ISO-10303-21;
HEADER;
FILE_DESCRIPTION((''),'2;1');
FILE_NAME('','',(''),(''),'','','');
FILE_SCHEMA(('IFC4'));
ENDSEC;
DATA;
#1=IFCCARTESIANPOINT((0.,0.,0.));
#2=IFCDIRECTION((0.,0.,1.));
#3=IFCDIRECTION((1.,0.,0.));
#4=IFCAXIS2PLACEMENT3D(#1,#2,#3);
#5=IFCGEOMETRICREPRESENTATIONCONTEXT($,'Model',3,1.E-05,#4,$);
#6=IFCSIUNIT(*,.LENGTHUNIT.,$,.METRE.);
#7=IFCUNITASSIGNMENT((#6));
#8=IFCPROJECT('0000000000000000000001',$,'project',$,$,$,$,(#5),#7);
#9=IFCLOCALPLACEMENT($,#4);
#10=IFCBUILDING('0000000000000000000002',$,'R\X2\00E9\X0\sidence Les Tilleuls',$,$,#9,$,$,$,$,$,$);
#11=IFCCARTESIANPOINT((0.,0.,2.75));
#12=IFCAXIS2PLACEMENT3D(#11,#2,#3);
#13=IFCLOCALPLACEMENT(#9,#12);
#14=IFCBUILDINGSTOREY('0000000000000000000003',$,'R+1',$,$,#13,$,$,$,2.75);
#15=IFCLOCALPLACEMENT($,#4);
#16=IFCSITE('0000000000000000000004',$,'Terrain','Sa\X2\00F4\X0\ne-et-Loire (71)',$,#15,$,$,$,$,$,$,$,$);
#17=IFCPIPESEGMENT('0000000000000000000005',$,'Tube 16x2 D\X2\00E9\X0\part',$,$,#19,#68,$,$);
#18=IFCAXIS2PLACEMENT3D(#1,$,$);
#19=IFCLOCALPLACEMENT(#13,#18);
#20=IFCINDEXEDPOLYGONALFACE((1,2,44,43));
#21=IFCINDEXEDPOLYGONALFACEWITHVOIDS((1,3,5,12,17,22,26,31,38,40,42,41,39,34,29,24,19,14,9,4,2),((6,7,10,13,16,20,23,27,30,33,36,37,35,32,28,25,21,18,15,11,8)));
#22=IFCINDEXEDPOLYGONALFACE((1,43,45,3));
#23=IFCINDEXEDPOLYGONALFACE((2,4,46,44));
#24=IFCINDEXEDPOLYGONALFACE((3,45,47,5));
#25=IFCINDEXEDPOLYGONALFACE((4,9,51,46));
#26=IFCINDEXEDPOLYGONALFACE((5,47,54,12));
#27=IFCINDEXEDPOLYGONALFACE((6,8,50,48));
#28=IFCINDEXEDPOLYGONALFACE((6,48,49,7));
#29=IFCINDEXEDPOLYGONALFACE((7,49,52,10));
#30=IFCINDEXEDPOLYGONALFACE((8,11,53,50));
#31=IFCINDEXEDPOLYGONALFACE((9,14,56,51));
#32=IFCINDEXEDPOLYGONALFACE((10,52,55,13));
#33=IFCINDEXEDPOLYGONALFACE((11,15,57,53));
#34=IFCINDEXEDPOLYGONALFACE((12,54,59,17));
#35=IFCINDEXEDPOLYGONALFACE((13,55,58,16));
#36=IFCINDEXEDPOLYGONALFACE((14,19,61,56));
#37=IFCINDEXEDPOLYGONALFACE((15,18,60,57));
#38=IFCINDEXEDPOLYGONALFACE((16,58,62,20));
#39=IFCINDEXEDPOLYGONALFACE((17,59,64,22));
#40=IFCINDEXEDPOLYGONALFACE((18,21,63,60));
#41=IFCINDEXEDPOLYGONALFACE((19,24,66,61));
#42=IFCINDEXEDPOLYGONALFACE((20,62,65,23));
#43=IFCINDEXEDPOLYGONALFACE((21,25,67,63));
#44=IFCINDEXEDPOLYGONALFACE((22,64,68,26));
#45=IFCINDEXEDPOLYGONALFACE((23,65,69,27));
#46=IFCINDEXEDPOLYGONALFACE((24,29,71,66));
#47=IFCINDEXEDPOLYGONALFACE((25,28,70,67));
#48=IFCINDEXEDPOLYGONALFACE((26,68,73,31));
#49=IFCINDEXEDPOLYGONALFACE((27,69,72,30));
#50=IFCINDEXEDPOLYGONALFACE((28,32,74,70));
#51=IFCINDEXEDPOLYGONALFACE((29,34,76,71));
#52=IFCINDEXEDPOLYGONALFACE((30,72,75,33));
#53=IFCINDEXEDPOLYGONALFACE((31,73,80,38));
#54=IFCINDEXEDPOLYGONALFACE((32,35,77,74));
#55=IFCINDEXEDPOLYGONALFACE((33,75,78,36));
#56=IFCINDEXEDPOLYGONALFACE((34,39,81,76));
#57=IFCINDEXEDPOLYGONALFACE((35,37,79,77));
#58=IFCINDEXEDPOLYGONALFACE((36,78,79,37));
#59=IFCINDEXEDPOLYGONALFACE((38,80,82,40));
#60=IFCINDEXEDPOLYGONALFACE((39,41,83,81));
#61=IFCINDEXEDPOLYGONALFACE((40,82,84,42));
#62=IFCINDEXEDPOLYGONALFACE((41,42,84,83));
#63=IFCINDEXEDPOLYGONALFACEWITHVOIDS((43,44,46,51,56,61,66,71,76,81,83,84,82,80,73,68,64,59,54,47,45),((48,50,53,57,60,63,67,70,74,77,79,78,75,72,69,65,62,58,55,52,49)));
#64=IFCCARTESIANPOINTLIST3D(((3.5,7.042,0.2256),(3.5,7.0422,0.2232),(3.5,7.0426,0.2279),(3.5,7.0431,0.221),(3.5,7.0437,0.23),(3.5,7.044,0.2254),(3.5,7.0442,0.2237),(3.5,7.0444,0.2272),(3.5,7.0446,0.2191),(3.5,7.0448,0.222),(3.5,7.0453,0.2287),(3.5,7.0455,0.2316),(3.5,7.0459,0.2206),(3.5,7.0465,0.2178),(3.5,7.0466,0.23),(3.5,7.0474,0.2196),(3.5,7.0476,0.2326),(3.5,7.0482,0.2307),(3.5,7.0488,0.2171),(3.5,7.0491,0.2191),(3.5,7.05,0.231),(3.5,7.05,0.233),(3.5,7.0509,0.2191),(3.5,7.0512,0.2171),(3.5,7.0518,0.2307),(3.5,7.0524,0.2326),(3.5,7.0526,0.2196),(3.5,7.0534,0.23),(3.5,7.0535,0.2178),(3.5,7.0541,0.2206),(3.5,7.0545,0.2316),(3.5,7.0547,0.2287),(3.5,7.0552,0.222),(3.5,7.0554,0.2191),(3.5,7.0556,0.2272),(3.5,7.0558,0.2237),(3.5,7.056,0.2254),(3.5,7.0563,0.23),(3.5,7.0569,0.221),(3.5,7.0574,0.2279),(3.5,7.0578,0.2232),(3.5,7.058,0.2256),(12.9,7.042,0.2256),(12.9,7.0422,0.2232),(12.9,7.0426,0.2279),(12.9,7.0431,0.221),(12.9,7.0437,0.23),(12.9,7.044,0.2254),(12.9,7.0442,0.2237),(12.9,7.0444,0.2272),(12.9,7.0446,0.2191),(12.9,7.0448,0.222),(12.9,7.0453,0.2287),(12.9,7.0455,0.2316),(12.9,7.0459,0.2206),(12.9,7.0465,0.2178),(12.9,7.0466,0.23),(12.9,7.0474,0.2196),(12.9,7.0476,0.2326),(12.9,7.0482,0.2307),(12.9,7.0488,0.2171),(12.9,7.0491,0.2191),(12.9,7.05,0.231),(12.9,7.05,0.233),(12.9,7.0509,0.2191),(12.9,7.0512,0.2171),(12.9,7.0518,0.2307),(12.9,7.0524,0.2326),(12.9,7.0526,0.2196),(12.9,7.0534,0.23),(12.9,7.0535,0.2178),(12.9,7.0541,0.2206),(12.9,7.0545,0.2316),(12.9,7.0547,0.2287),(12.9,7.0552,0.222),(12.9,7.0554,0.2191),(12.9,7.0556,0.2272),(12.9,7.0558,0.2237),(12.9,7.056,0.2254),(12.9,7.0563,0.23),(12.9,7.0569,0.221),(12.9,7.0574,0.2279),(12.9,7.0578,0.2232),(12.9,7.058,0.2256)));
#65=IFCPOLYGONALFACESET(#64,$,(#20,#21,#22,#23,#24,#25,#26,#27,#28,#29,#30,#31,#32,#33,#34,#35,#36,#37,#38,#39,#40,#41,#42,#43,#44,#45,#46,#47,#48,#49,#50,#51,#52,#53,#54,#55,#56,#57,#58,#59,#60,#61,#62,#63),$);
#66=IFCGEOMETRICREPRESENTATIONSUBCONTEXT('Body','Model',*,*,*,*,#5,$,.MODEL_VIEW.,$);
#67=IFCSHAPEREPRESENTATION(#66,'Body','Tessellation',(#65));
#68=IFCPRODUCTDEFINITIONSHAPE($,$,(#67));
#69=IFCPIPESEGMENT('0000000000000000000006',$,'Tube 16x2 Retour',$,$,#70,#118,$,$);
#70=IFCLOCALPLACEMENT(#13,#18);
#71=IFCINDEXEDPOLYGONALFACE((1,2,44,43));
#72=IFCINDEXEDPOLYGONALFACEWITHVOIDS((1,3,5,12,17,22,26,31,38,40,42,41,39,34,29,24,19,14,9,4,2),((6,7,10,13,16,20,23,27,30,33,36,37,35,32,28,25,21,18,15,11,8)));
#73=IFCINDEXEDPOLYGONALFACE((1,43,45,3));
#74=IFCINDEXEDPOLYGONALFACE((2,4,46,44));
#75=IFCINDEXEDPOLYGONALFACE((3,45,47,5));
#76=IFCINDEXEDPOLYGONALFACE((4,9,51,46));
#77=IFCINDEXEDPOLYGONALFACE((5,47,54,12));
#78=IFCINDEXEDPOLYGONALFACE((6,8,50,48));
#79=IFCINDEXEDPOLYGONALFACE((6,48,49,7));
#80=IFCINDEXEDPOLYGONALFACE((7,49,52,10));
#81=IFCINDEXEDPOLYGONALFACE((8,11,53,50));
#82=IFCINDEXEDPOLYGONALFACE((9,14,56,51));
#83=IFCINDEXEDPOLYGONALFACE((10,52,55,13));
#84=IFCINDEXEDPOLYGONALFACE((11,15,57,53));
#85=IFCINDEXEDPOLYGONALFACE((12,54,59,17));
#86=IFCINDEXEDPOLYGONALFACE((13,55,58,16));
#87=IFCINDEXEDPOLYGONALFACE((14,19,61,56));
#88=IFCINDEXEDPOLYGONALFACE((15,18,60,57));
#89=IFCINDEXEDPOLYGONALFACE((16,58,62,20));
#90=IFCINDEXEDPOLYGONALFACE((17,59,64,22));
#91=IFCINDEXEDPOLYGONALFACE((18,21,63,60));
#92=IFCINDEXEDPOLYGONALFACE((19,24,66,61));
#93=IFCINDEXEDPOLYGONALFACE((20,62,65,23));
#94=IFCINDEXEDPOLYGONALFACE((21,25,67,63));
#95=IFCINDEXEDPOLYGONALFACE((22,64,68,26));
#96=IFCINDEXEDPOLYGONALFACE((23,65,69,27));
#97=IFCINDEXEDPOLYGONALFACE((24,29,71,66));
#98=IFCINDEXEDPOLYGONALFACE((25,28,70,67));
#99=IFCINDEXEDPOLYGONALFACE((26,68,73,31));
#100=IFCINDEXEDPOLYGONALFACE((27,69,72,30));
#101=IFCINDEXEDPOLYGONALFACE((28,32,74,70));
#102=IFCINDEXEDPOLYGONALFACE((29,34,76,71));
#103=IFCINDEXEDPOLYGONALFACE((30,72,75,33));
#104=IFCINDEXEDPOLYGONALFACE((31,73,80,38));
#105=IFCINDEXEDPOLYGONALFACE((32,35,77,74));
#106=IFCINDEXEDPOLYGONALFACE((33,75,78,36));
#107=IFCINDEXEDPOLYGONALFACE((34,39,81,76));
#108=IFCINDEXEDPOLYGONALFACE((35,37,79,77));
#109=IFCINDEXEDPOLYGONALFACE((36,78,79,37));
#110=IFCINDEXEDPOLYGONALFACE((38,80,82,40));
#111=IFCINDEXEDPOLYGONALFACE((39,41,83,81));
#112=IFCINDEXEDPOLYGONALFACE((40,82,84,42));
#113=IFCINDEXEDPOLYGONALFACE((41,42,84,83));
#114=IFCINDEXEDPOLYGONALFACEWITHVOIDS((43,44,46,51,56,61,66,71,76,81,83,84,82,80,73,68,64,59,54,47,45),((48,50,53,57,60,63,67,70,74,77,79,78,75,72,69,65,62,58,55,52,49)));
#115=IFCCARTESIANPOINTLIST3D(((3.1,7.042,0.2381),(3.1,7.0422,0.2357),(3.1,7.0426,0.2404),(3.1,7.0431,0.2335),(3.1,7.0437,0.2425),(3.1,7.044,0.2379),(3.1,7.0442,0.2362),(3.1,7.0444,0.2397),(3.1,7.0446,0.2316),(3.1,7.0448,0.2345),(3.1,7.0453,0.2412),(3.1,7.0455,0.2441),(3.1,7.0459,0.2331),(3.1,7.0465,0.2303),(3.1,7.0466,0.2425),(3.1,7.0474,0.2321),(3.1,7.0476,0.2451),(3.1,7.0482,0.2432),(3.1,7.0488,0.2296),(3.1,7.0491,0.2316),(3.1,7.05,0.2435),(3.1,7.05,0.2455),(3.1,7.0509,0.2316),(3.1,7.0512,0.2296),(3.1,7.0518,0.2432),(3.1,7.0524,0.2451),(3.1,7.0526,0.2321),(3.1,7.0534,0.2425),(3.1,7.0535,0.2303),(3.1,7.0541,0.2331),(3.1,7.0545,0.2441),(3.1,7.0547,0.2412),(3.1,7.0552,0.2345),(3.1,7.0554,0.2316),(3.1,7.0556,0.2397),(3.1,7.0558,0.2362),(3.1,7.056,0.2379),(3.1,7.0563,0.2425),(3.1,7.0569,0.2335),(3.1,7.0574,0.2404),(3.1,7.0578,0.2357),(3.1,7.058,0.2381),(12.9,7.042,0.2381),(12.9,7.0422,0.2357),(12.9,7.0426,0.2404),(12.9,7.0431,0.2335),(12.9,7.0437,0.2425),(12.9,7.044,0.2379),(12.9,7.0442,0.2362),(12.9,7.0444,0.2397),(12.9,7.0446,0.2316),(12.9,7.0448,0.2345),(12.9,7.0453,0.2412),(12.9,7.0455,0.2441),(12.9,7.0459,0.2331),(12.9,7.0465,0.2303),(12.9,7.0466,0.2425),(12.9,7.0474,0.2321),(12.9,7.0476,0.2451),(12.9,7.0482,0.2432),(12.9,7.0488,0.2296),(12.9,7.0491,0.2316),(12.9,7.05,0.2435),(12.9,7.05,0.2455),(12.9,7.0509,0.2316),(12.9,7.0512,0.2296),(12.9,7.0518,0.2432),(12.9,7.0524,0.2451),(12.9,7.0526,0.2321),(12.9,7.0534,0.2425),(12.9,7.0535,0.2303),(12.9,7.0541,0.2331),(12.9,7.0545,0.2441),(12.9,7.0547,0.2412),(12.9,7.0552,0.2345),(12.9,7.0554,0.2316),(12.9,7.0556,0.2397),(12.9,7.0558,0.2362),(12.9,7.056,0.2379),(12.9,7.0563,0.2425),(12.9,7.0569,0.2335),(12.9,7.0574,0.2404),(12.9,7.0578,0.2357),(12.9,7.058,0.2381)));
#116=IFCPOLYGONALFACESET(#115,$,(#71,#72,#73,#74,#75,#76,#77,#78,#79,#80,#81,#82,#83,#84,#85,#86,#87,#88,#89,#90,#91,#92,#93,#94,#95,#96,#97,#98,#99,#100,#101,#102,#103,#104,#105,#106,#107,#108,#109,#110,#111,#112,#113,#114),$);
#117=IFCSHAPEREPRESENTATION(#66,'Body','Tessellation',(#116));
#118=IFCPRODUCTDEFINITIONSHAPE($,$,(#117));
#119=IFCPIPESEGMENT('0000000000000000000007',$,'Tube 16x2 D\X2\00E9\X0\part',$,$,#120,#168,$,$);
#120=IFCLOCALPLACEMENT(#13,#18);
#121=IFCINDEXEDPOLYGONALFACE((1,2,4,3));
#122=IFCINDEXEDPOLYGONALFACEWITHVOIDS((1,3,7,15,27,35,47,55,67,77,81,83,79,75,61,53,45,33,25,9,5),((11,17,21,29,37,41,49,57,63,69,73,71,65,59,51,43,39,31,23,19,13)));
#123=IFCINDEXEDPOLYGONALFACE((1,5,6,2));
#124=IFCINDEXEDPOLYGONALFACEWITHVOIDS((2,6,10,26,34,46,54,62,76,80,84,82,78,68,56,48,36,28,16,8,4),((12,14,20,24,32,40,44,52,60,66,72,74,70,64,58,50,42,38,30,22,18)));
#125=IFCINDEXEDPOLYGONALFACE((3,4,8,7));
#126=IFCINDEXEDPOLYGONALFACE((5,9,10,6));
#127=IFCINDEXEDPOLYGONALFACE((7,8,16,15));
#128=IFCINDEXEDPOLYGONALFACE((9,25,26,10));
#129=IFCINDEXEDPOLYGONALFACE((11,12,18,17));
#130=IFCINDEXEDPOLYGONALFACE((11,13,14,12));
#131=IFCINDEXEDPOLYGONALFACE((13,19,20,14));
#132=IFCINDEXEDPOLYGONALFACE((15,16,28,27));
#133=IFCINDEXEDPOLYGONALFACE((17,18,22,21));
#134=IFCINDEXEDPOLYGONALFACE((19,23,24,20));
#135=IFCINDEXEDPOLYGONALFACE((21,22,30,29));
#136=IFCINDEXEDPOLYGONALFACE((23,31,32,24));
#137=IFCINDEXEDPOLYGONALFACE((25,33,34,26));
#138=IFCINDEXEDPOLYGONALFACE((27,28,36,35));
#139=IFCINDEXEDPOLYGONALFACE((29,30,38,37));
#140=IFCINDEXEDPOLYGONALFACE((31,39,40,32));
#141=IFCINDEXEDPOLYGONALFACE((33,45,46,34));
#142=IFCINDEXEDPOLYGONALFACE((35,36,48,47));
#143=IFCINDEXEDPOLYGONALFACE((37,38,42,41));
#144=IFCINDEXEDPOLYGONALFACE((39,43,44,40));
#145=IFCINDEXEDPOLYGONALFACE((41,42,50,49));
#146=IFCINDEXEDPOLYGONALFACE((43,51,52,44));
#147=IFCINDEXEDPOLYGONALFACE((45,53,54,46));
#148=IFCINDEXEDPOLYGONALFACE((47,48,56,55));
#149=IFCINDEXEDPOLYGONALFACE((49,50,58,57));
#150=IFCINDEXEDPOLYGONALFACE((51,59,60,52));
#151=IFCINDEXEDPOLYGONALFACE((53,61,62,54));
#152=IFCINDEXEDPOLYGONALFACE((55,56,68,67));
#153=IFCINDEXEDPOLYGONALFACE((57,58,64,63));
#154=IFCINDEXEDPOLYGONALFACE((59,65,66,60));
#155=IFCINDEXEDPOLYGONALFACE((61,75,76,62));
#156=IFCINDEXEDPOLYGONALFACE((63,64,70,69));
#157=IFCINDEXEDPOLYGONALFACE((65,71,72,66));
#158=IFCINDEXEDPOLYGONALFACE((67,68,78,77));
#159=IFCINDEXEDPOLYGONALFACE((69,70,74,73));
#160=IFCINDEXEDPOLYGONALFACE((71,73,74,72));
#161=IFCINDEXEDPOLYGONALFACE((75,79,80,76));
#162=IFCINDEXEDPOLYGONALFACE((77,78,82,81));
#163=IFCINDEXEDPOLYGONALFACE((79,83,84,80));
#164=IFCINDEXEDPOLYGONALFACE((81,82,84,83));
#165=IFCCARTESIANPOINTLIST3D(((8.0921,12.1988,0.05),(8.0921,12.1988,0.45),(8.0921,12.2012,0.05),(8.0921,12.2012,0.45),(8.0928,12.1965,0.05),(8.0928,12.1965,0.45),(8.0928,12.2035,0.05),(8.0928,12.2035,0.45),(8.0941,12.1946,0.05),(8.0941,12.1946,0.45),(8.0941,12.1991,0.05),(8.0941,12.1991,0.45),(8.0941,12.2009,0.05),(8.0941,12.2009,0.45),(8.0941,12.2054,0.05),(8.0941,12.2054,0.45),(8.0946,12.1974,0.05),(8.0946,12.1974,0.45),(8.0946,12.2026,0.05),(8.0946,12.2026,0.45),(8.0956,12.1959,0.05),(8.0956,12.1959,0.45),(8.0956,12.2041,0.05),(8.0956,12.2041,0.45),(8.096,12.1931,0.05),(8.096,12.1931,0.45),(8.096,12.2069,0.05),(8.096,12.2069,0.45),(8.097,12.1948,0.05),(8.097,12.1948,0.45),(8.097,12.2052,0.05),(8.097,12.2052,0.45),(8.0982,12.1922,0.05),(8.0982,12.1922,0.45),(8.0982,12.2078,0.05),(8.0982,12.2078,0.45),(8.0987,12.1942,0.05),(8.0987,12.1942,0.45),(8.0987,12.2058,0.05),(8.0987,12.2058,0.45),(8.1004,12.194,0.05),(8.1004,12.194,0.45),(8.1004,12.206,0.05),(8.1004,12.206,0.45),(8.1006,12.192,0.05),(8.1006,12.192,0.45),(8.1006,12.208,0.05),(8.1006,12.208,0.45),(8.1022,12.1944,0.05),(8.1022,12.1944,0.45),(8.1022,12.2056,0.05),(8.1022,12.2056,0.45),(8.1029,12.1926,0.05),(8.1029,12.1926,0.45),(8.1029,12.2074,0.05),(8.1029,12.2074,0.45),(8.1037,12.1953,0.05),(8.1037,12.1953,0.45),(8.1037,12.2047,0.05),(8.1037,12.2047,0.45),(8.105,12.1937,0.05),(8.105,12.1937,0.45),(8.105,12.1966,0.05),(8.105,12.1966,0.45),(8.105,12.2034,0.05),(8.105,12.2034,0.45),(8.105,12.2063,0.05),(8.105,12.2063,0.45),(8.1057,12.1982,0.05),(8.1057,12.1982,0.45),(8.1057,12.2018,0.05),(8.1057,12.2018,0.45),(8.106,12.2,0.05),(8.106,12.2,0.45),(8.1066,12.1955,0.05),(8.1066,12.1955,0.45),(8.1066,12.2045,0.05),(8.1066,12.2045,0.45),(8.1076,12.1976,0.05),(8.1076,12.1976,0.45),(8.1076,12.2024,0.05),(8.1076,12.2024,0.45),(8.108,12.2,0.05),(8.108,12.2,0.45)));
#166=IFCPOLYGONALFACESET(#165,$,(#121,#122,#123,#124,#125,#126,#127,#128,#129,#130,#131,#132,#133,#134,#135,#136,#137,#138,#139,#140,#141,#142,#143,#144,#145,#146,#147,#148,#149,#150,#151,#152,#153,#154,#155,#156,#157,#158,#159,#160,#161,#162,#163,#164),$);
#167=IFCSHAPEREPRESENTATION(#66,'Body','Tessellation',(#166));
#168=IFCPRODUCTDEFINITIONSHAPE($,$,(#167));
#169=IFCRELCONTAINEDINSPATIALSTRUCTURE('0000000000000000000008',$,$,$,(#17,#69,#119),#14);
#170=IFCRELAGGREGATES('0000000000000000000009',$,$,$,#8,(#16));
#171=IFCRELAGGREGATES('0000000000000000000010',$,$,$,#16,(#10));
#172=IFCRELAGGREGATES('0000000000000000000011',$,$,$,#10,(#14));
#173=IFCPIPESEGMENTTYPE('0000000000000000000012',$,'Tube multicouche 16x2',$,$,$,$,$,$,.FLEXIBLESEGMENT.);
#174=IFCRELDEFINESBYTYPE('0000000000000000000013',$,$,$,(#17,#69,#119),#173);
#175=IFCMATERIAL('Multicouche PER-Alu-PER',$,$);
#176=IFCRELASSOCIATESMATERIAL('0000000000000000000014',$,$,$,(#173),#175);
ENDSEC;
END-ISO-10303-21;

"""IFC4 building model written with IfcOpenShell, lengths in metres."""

from ifc_helpers import new_model, si_unit, frame, origin_with_axes, place, context, subcontext, project, spatial, hollow_circle, extrude, material, type_object, element, save


model = new_model("IFC4")

# Units and contexts
model_context = context("Model", 3, precision=1e-05, world=origin_with_axes())
body_context = subcontext(model_context, "Body", "Model", "MODEL_VIEW")
ifc_project = project(units=[si_unit("LENGTHUNIT", "METRE")], contexts=[model_context])

# Site, building, storey
site_placement = place(None, origin_with_axes())
site = spatial("IfcSite", under=ifc_project, at=site_placement, Name="Terrain", Description="Saône-et-Loire (71)")
building_placement = place(None, origin_with_axes())
building = spatial("IfcBuilding", under=site, at=building_placement, Name="Résidence Les Tilleuls")
storey_placement = place(building_placement, frame((0.0, 0.0, 2.75), z_axis=(0.0, 0.0, 1.0), x_axis=(1.0, 0.0, 0.0)))
storey = spatial("IfcBuildingStorey", under=building, at=storey_placement, Name="R+1", Elevation=2.75)

# Pipe segments
ifc_material_1 = material(Name="Multicouche PER-Alu-PER")
pipe_segment_type_1 = type_object("IfcPipeSegmentType", Name="Tube multicouche 16x2", PredefinedType="FLEXIBLESEGMENT", material=ifc_material_1)
pipe_segment_1_placement = place(storey_placement, frame((12.9, 7.05, 0.225), z_axis=(-1.0, 0.0, 0.0), x_axis=(0.0, 0.0, 1.0)))
element("IfcPipeSegment", 1, at=pipe_segment_1_placement, inside=storey, type_object=pipe_segment_type_1, Name="Tube 16x2 Départ", context=body_context, shape_type="SweptSolid", body=[
    extrude(hollow_circle(Radius=0.008, WallThickness=0.002), origin_with_axes(), (0.0, 0.0, 1.0), 9.4),
])
pipe_segment_2_placement = place(storey_placement, frame((12.9, 7.05, 0.2375), z_axis=(-1.0, 0.0, 0.0), x_axis=(0.0, 0.0, 1.0)))
element("IfcPipeSegment", 2, at=pipe_segment_2_placement, inside=storey, type_object=pipe_segment_type_1, Name="Tube 16x2 Retour", context=body_context, shape_type="SweptSolid", body=[
    extrude(hollow_circle(Radius=0.008, WallThickness=0.002), origin_with_axes(), (0.0, 0.0, 1.0), 9.8),
])
pipe_segment_3_placement = place(storey_placement, frame((8.1, 12.2, 0.05), z_axis=(0.0, 0.0, 1.0), x_axis=(1.0, 0.0, 0.0)))
element("IfcPipeSegment", 3, at=pipe_segment_3_placement, inside=storey, type_object=pipe_segment_type_1, Name="Tube 16x2 Départ", context=body_context, shape_type="SweptSolid", body=[
    extrude(hollow_circle(Radius=0.008, WallThickness=0.002), origin_with_axes(), (0.0, 0.0, 1.0), 0.4),
])

save(model, "model.ifc")
